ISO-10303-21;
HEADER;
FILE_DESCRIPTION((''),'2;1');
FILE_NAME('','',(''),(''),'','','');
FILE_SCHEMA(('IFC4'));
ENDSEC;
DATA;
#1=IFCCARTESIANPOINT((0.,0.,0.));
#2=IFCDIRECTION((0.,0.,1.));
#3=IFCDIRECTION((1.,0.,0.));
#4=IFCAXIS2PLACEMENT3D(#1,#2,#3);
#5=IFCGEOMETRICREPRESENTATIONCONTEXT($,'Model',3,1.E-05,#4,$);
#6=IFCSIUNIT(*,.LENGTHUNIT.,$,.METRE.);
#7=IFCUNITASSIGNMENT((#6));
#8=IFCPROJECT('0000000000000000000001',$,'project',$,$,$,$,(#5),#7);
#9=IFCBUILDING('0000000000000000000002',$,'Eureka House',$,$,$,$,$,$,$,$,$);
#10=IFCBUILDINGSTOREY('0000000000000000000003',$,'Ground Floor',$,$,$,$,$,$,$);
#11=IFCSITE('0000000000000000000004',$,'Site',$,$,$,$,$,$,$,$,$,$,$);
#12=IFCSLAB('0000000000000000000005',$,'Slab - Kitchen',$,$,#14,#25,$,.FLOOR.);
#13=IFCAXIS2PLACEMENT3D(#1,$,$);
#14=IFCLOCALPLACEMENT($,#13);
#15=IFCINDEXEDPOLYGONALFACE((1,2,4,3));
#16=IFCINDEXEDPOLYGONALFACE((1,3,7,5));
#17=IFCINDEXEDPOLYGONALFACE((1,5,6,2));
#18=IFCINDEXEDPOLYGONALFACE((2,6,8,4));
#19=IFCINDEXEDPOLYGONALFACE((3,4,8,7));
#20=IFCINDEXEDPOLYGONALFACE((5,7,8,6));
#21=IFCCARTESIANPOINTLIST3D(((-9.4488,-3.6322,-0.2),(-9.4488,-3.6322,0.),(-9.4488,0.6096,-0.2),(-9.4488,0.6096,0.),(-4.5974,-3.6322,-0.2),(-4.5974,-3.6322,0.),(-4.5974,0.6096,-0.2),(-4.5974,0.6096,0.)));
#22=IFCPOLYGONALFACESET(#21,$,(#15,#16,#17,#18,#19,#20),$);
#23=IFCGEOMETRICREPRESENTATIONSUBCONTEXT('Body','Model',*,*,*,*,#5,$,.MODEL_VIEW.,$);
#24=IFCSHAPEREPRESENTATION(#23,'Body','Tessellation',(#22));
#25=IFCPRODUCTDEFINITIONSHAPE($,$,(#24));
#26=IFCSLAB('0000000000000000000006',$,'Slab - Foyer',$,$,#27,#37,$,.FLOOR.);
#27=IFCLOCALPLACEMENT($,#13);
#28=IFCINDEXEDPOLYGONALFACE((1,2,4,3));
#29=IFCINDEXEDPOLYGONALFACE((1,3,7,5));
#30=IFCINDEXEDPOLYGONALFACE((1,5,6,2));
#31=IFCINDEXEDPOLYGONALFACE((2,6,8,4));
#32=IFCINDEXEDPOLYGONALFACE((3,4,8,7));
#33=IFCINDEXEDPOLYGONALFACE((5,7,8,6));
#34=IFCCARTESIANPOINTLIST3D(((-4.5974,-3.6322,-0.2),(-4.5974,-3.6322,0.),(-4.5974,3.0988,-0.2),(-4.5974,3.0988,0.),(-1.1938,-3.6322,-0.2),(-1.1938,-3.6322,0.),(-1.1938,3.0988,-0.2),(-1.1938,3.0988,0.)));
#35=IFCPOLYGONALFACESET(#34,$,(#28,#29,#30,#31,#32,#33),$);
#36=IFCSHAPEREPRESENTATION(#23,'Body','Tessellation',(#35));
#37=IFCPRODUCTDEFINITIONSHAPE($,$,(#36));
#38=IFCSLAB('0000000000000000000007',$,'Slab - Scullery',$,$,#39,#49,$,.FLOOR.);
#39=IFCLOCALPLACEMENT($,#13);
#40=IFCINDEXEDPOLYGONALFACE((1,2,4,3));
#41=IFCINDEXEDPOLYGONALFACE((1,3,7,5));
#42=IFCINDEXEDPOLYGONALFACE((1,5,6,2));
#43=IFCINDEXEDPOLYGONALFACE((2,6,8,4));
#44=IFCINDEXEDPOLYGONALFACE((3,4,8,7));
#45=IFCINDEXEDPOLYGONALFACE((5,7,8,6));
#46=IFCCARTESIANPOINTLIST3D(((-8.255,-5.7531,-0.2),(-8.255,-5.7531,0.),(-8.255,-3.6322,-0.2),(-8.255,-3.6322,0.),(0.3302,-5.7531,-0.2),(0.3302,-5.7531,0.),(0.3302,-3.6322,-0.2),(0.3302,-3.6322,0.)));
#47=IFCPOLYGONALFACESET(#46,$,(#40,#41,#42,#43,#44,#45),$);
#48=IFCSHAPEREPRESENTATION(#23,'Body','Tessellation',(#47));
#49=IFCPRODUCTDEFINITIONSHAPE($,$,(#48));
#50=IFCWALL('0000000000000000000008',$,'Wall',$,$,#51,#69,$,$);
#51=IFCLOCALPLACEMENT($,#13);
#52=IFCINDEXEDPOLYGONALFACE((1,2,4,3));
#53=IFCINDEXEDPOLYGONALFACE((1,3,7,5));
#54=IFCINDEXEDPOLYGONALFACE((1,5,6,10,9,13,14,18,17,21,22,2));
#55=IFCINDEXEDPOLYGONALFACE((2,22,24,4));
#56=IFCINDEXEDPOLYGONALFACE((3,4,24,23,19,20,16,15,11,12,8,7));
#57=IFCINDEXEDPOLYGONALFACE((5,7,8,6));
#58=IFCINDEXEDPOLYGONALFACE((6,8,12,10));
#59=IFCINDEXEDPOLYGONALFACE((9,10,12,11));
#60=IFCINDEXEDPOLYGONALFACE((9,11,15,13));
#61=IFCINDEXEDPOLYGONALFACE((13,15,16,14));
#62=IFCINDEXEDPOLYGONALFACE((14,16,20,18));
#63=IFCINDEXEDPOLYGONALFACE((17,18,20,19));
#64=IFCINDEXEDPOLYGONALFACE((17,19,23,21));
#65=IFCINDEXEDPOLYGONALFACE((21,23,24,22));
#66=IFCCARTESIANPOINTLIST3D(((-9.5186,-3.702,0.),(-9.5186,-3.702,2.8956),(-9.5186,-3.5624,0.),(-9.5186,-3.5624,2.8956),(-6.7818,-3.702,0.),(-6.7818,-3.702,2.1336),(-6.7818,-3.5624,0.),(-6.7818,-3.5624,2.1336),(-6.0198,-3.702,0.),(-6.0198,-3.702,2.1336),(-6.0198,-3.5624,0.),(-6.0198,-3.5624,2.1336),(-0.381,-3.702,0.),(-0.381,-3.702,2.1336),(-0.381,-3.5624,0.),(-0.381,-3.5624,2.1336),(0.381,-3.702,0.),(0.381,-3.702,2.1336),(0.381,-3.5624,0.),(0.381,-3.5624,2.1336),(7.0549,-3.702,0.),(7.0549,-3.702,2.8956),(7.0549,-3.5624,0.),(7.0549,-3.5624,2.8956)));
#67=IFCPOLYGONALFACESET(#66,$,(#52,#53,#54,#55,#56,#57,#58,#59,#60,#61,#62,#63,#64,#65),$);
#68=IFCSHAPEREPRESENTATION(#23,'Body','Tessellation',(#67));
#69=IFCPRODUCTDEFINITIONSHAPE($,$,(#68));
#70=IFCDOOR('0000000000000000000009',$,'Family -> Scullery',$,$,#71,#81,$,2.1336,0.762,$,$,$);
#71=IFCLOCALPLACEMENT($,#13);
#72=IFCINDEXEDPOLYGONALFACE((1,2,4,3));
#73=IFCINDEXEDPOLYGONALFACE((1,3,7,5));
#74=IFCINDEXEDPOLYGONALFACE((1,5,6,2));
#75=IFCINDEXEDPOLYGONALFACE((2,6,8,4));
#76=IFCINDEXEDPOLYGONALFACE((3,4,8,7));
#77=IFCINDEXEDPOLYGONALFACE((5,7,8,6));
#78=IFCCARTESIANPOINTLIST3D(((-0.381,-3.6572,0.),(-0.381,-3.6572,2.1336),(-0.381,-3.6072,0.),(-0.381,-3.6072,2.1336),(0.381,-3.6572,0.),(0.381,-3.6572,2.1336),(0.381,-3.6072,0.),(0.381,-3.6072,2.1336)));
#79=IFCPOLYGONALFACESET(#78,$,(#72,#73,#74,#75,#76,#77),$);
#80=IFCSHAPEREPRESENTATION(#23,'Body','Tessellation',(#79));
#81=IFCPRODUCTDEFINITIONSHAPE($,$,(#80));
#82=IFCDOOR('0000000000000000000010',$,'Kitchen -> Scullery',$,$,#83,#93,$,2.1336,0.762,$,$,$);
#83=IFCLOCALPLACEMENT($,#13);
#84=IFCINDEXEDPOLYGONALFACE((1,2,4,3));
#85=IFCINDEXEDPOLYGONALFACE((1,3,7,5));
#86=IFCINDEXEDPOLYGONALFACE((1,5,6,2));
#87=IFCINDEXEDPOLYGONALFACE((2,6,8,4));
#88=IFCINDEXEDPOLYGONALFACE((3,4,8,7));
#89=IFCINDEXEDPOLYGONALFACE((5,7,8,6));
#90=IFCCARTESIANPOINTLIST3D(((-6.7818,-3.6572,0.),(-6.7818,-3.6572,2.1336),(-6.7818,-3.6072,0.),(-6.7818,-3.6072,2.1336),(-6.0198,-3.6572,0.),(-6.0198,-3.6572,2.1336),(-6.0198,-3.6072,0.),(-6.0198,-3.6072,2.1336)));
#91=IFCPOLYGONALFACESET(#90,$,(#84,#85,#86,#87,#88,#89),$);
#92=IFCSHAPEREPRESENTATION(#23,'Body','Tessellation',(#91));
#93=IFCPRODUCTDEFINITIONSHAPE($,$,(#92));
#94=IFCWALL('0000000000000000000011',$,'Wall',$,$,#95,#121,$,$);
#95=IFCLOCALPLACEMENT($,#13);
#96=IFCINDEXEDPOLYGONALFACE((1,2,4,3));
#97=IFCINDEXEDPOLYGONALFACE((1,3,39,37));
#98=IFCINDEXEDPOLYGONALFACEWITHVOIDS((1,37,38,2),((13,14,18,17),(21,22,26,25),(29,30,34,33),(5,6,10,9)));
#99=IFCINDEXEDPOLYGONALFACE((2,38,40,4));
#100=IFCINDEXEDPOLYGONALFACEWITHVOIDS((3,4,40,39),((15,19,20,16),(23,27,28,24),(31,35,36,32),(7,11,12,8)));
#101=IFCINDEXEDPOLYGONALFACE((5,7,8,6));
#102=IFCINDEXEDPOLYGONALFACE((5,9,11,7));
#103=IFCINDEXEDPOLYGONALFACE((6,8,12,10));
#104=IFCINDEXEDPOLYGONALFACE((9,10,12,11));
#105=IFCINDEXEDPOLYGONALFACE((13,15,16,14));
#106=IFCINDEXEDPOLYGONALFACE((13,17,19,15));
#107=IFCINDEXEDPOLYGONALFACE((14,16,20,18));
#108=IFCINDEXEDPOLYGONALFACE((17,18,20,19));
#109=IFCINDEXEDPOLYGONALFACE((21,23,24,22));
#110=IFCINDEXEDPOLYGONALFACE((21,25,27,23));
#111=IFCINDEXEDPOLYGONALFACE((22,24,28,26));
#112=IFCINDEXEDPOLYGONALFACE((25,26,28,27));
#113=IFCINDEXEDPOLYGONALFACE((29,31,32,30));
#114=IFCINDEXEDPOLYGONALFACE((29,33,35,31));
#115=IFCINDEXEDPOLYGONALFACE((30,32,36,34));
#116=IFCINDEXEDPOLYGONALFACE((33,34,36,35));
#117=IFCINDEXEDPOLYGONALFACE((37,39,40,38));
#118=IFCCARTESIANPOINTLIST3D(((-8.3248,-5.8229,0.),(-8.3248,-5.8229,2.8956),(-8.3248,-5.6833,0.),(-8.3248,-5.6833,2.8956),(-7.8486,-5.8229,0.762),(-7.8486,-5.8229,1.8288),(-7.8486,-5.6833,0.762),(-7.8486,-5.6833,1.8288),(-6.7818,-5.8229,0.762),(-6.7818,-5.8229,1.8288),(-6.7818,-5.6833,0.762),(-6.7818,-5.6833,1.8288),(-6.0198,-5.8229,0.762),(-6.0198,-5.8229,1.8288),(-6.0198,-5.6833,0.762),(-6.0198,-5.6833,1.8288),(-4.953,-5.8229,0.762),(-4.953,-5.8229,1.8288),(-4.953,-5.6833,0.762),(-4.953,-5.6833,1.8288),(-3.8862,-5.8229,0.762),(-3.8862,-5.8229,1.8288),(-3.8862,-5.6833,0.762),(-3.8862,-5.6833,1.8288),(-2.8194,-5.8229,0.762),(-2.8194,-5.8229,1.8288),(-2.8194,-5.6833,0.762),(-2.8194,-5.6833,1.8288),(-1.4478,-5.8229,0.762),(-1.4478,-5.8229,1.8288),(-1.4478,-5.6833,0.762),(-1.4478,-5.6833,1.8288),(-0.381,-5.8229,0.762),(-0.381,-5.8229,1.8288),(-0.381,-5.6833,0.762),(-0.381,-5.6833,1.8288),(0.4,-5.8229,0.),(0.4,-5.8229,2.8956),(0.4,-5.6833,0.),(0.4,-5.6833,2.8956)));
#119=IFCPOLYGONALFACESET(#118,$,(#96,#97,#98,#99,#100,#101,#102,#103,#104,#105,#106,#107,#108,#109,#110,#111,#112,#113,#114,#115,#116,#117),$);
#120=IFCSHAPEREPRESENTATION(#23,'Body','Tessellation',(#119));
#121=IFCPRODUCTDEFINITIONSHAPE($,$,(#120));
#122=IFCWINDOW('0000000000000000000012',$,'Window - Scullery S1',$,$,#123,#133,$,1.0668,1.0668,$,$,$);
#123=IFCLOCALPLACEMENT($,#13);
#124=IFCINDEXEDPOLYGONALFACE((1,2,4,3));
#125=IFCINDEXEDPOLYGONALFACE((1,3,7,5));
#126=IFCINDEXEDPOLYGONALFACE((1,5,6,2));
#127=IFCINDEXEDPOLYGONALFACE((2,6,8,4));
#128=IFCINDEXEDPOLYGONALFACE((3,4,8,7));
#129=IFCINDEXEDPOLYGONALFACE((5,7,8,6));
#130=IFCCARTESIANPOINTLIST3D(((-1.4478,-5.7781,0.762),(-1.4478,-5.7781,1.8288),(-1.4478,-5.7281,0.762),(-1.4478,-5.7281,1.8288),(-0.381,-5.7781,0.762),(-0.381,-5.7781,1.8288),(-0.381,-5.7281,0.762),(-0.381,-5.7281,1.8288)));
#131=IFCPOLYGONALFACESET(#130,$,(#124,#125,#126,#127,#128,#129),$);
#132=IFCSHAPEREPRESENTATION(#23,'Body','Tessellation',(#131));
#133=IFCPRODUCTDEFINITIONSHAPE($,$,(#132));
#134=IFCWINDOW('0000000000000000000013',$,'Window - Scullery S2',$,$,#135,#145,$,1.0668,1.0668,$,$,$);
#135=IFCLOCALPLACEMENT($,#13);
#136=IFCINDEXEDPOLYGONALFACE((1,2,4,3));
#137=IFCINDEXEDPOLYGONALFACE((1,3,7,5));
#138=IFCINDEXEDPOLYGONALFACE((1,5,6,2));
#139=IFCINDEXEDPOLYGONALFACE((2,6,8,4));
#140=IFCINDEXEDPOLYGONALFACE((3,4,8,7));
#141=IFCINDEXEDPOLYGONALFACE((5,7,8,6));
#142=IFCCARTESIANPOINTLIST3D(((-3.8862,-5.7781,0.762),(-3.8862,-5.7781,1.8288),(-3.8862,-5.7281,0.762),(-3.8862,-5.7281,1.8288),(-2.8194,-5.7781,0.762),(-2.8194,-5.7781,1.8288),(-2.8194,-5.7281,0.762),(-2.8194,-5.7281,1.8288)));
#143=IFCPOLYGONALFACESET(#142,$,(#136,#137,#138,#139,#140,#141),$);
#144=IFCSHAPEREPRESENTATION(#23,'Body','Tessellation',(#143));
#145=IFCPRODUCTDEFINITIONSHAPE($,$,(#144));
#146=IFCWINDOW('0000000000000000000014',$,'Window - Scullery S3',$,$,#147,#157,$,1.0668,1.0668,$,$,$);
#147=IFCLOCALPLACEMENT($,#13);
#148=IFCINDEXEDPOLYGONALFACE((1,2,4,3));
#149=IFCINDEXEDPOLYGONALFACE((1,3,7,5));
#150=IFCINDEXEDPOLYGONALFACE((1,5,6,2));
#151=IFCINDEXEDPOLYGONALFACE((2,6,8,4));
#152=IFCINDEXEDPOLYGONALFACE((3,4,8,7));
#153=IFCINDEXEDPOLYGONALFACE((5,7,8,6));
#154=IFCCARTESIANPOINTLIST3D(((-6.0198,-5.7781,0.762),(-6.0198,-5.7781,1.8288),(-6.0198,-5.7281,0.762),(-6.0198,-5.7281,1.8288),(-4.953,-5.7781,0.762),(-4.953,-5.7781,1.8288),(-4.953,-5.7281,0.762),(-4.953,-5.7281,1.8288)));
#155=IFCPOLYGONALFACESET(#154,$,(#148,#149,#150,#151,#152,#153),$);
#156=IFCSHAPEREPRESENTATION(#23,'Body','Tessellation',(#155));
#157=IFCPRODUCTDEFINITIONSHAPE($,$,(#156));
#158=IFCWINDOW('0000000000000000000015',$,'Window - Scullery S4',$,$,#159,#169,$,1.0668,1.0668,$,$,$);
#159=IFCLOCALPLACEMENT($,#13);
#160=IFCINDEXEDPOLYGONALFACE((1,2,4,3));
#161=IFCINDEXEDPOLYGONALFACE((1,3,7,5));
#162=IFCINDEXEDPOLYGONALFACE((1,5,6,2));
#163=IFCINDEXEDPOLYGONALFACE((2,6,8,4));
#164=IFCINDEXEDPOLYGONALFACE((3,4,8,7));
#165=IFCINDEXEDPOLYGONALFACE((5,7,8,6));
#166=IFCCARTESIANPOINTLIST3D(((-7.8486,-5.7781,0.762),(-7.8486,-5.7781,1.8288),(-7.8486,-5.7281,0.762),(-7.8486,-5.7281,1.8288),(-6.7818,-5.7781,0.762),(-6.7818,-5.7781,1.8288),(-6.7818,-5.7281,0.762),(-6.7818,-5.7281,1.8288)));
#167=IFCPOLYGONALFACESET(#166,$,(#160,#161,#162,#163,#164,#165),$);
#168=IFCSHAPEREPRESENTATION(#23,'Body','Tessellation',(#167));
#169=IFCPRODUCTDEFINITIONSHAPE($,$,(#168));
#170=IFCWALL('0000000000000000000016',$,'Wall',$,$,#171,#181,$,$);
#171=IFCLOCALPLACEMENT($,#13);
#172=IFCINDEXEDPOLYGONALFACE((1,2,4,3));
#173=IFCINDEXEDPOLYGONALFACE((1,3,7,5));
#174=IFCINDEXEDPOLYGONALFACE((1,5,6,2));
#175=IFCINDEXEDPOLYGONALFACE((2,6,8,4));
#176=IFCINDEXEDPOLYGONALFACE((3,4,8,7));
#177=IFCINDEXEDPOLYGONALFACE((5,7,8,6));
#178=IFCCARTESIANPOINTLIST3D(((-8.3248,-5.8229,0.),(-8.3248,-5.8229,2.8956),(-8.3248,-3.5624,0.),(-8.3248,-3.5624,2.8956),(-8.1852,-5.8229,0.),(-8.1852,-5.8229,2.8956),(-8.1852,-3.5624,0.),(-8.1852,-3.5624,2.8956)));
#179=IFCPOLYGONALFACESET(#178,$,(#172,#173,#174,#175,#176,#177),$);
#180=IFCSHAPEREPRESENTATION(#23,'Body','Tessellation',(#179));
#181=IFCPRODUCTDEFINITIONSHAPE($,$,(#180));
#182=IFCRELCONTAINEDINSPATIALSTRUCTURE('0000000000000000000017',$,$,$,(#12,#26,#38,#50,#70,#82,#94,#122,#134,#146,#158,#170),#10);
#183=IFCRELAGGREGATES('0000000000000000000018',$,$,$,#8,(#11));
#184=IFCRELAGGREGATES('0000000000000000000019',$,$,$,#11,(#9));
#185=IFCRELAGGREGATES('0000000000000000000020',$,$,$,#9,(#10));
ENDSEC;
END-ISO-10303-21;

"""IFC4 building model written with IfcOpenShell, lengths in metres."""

from ifc_helpers import new_model, si_unit, frame, origin, origin_with_axes, origin_2d, place, context, subcontext, project, spatial, rectangle, extrude, element, fill, save


model = new_model("IFC4")

# Units and contexts
model_context = context("Model", 3, precision=1e-05, world=origin_with_axes())
body_context = subcontext(model_context, "Body", "Model", "MODEL_VIEW")
ifc_project = project(units=[si_unit("LENGTHUNIT", "METRE")], contexts=[model_context])

# Site, building, storey
site = spatial("IfcSite", under=ifc_project, Name="Site")
building = spatial("IfcBuilding", under=site, Name="Eureka House")
storey = spatial("IfcBuildingStorey", under=building, Name="Ground Floor")

# Slabs
slab_1_placement = place(None, frame((-7.0231, -1.5113, -0.2), z_axis=(0.0, 0.0, 1.0), x_axis=(1.0, 0.0, 0.0)))
element("IfcSlab", 1, at=slab_1_placement, inside=storey, Name="Slab - Kitchen", PredefinedType="FLOOR", context=body_context, shape_type="SweptSolid", body=[
    extrude(rectangle(XDim=4.8514, YDim=4.2418, at=origin_2d()), origin(), (0.0, 0.0, 1.0), 0.2),
])
slab_2_placement = place(None, frame((-2.8956, -0.2667, -0.2), z_axis=(0.0, 0.0, 1.0), x_axis=(1.0, 0.0, 0.0)))
element("IfcSlab", 2, at=slab_2_placement, inside=storey, Name="Slab - Foyer", PredefinedType="FLOOR", context=body_context, shape_type="SweptSolid", body=[
    extrude(rectangle(XDim=3.4036, YDim=6.731, at=origin_2d()), origin(), (0.0, 0.0, 1.0), 0.2),
])
slab_3_placement = place(None, frame((-3.9624, -4.6927, -0.2), z_axis=(0.0, 0.0, 1.0), x_axis=(1.0, 0.0, 0.0)))
element("IfcSlab", 3, at=slab_3_placement, inside=storey, Name="Slab - Scullery", PredefinedType="FLOOR", context=body_context, shape_type="SweptSolid", body=[
    extrude(rectangle(XDim=8.5852, YDim=2.1209, at=origin_2d()), origin(), (0.0, 0.0, 1.0), 0.2),
])

# Wall, openings, doors
wall_1_placement = place(None, frame((-1.2319, -3.6322, 0.0), z_axis=(0.0, 0.0, 1.0), x_axis=(1.0, 0.0, 0.0)))
wall_1 = element("IfcWall", 4, at=wall_1_placement, inside=storey, Name="Wall", context=body_context, shape_type="SweptSolid", body=[
    extrude(rectangle(XDim=16.5735, YDim=0.1397, at=origin_2d()), origin(), (0.0, 0.0, 1.0), 2.8956),
])
opening_1_placement = place(wall_1_placement, frame((1.2319, 0.0, 0.0), z_axis=(0.0, 0.0, 1.0), x_axis=(1.0, 0.0, 0.0)))
opening_1 = element("IfcOpeningElement", 5, at=opening_1_placement, cuts=wall_1, context=body_context, shape_type="SweptSolid", body=[
    extrude(rectangle(XDim=0.762, YDim=0.2397, at=origin_2d()), origin(), (0.0, 0.0, 1.0), 2.1336),
])
opening_2_placement = place(wall_1_placement, frame((-5.1689, 0.0, 0.0), z_axis=(0.0, 0.0, 1.0), x_axis=(1.0, 0.0, 0.0)))
opening_2 = element("IfcOpeningElement", 6, at=opening_2_placement, cuts=wall_1, context=body_context, shape_type="SweptSolid", body=[
    extrude(rectangle(XDim=0.762, YDim=0.2397, at=origin_2d()), origin(), (0.0, 0.0, 1.0), 2.1336),
])
door_1_placement = place(opening_1_placement, origin_with_axes())
door_1 = element("IfcDoor", 7, at=door_1_placement, inside=storey, Name="Family -> Scullery", OverallHeight=2.1336, OverallWidth=0.762, context=body_context, shape_type="SweptSolid", body=[
    extrude(rectangle(XDim=0.762, YDim=0.05, at=origin_2d()), origin(), (0.0, 0.0, 1.0), 2.1336),
])
fill(opening_1, door_1)
door_2_placement = place(opening_2_placement, origin_with_axes())
door_2 = element("IfcDoor", 8, at=door_2_placement, inside=storey, Name="Kitchen -> Scullery", OverallHeight=2.1336, OverallWidth=0.762, context=body_context, shape_type="SweptSolid", body=[
    extrude(rectangle(XDim=0.762, YDim=0.05, at=origin_2d()), origin(), (0.0, 0.0, 1.0), 2.1336),
])
fill(opening_2, door_2)

# Wall, openings, windows
wall_2_placement = place(None, frame((-3.9624, -5.7531, 0.0), z_axis=(0.0, 0.0, 1.0), x_axis=(1.0, 0.0, 0.0)))
wall_2 = element("IfcWall", 9, at=wall_2_placement, inside=storey, Name="Wall", context=body_context, shape_type="SweptSolid", body=[
    extrude(rectangle(XDim=8.7249, YDim=0.1397, at=origin_2d()), origin(), (0.0, 0.0, 1.0), 2.8956),
])
opening_3_placement = place(wall_2_placement, frame((3.048, 0.0, 0.762), z_axis=(0.0, 0.0, 1.0), x_axis=(1.0, 0.0, 0.0)))
opening_3 = element("IfcOpeningElement", 10, at=opening_3_placement, cuts=wall_2, context=body_context, shape_type="SweptSolid", body=[
    extrude(rectangle(XDim=1.0668, YDim=0.2397, at=origin_2d()), origin(), (0.0, 0.0, 1.0), 1.0668),
])
opening_4_placement = place(wall_2_placement, frame((0.6096, 0.0, 0.762), z_axis=(0.0, 0.0, 1.0), x_axis=(1.0, 0.0, 0.0)))
opening_4 = element("IfcOpeningElement", 11, at=opening_4_placement, cuts=wall_2, context=body_context, shape_type="SweptSolid", body=[
    extrude(rectangle(XDim=1.0668, YDim=0.2397, at=origin_2d()), origin(), (0.0, 0.0, 1.0), 1.0668),
])
opening_5_placement = place(wall_2_placement, frame((-1.524, 0.0, 0.762), z_axis=(0.0, 0.0, 1.0), x_axis=(1.0, 0.0, 0.0)))
opening_5 = element("IfcOpeningElement", 12, at=opening_5_placement, cuts=wall_2, context=body_context, shape_type="SweptSolid", body=[
    extrude(rectangle(XDim=1.0668, YDim=0.2397, at=origin_2d()), origin(), (0.0, 0.0, 1.0), 1.0668),
])
opening_6_placement = place(wall_2_placement, frame((-3.3528, 0.0, 0.762), z_axis=(0.0, 0.0, 1.0), x_axis=(1.0, 0.0, 0.0)))
opening_6 = element("IfcOpeningElement", 13, at=opening_6_placement, cuts=wall_2, context=body_context, shape_type="SweptSolid", body=[
    extrude(rectangle(XDim=1.0668, YDim=0.2397, at=origin_2d()), origin(), (0.0, 0.0, 1.0), 1.0668),
])
window_1_placement = place(opening_3_placement, origin_with_axes())
window_1 = element("IfcWindow", 14, at=window_1_placement, inside=storey, Name="Window - Scullery S1", OverallHeight=1.0668, OverallWidth=1.0668, context=body_context, shape_type="SweptSolid", body=[
    extrude(rectangle(XDim=1.0668, YDim=0.05, at=origin_2d()), origin(), (0.0, 0.0, 1.0), 1.0668),
])
fill(opening_3, window_1)
window_2_placement = place(opening_4_placement, origin_with_axes())
window_2 = element("IfcWindow", 15, at=window_2_placement, inside=storey, Name="Window - Scullery S2", OverallHeight=1.0668, OverallWidth=1.0668, context=body_context, shape_type="SweptSolid", body=[
    extrude(rectangle(XDim=1.0668, YDim=0.05, at=origin_2d()), origin(), (0.0, 0.0, 1.0), 1.0668),
])
fill(opening_4, window_2)
window_3_placement = place(opening_5_placement, origin_with_axes())
window_3 = element("IfcWindow", 16, at=window_3_placement, inside=storey, Name="Window - Scullery S3", OverallHeight=1.0668, OverallWidth=1.0668, context=body_context, shape_type="SweptSolid", body=[
    extrude(rectangle(XDim=1.0668, YDim=0.05, at=origin_2d()), origin(), (0.0, 0.0, 1.0), 1.0668),
])
fill(opening_5, window_3)
window_4_placement = place(opening_6_placement, origin_with_axes())
window_4 = element("IfcWindow", 17, at=window_4_placement, inside=storey, Name="Window - Scullery S4", OverallHeight=1.0668, OverallWidth=1.0668, context=body_context, shape_type="SweptSolid", body=[
    extrude(rectangle(XDim=1.0668, YDim=0.05, at=origin_2d()), origin(), (0.0, 0.0, 1.0), 1.0668),
])
fill(opening_6, window_4)

# Wall
wall_3_placement = place(None, frame((-8.255, -4.6927, 0.0), z_axis=(0.0, 0.0, 1.0), x_axis=(1.0, 0.0, 0.0)))
element("IfcWall", 18, at=wall_3_placement, inside=storey, Name="Wall", context=body_context, shape_type="SweptSolid", body=[
    extrude(rectangle(XDim=0.1397, YDim=2.2606, at=origin_2d()), origin(), (0.0, 0.0, 1.0), 2.8956),
])

save(model, "model.ifc")
